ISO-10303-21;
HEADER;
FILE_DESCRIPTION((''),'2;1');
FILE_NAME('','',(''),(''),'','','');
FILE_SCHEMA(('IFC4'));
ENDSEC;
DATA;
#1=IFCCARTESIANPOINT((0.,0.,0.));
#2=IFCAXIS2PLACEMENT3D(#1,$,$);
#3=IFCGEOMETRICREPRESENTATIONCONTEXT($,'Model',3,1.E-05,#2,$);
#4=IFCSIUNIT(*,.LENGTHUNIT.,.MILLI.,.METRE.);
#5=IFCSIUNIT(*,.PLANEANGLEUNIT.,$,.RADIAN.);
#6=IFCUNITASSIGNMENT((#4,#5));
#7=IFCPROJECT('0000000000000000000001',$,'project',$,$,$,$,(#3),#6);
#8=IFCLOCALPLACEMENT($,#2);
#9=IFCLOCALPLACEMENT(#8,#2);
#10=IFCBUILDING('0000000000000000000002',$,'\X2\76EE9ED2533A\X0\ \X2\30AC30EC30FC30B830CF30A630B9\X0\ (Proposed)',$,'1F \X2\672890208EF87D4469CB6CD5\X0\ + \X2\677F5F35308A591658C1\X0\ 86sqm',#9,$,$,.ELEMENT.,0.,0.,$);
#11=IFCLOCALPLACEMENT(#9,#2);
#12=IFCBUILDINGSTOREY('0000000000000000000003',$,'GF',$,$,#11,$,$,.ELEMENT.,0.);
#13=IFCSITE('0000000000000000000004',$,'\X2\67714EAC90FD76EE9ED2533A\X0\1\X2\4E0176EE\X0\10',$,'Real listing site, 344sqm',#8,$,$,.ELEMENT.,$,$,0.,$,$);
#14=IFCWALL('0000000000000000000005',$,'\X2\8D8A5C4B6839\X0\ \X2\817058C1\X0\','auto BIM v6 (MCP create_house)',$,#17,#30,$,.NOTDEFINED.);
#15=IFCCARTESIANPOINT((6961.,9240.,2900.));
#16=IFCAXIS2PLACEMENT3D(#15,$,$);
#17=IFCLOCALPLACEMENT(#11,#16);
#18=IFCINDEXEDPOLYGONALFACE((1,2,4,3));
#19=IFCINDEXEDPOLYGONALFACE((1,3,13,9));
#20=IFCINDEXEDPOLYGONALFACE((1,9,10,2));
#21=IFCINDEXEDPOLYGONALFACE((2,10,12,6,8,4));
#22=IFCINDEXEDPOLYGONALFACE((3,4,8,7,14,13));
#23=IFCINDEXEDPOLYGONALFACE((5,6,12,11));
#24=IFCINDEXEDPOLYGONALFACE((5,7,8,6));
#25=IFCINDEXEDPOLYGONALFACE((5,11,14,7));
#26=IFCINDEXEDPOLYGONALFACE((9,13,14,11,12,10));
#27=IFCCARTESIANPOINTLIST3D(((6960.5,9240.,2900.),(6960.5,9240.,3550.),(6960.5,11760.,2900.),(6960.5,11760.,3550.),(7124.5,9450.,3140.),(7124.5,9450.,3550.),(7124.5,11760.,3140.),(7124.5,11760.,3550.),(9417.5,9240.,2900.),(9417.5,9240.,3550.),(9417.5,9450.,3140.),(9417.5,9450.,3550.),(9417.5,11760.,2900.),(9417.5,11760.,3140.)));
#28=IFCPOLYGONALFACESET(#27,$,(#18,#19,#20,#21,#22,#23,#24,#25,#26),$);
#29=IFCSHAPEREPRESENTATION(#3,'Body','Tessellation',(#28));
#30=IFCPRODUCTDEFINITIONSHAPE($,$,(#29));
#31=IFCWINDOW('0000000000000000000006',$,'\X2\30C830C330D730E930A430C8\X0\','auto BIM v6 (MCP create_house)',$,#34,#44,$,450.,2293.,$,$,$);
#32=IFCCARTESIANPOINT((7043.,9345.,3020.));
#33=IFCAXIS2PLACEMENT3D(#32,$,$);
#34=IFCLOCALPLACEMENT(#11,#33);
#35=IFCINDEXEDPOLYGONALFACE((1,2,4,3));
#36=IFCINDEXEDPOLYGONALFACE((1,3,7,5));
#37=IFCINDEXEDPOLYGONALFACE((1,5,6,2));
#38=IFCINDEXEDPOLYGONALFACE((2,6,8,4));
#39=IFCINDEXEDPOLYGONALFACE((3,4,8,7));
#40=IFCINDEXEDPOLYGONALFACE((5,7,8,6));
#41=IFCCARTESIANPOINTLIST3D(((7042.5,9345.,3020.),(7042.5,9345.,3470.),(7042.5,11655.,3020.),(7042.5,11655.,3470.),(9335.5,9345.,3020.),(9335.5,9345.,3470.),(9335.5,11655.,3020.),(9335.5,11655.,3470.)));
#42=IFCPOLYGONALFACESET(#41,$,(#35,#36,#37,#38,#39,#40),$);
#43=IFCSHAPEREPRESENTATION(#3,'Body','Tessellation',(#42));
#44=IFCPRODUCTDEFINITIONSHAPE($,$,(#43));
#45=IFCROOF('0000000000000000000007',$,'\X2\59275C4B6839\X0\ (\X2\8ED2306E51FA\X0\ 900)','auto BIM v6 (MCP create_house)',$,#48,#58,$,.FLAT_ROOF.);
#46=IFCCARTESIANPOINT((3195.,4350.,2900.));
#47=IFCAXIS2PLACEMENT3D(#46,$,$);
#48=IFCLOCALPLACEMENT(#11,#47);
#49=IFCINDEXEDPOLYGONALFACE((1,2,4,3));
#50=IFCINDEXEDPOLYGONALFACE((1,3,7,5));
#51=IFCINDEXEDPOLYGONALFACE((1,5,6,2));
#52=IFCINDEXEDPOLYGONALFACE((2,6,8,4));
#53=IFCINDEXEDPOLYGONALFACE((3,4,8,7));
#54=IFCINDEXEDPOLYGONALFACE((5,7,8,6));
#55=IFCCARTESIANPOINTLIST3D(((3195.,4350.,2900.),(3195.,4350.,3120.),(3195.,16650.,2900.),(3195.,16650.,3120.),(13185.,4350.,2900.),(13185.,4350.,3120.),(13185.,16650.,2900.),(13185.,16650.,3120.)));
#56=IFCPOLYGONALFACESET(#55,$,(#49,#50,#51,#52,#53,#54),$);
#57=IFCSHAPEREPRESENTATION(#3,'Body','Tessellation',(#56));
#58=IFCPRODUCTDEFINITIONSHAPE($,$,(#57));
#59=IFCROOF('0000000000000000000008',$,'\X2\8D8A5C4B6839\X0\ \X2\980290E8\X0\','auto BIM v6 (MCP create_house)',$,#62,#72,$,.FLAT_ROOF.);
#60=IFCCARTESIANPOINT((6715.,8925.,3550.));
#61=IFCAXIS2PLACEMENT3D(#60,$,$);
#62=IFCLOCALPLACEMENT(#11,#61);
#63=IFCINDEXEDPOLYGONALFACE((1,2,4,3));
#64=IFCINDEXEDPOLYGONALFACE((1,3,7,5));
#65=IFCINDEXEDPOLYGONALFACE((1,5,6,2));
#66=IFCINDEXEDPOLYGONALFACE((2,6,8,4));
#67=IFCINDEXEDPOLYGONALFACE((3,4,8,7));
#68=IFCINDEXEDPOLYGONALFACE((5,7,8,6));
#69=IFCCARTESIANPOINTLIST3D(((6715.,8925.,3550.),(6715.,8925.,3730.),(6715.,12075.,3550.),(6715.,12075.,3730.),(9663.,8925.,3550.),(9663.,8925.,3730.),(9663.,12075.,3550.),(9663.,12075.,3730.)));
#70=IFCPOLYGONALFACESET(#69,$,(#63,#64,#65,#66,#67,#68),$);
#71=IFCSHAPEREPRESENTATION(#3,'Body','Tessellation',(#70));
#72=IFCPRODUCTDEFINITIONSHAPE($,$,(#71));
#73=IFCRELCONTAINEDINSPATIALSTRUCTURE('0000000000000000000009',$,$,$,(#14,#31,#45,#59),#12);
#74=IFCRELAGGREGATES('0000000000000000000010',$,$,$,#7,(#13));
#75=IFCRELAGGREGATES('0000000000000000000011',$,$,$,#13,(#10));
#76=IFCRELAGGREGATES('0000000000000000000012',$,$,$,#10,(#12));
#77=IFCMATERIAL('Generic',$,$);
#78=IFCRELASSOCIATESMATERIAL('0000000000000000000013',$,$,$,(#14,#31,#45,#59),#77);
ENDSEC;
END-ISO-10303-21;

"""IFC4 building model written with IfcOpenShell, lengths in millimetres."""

from ifc_helpers import new_model, si_unit, frame, frame_2d, origin, place, context, project, spatial, rectangle, extrude, material, element, fill, save


model = new_model("IFC4")

# Units and contexts
model_context = context("Model", 3, precision=1e-05, world=origin())
ifc_project = project(units=[si_unit("LENGTHUNIT", "METRE", prefix="MILLI"), si_unit("PLANEANGLEUNIT", "RADIAN")], contexts=[model_context])

# Site, building, storey
site_placement = place(None, origin())
site = spatial("IfcSite", under=ifc_project, at=site_placement, Name="東京都目黒区1丁目10", ObjectType="Real listing site, 344sqm", CompositionType="ELEMENT", RefElevation=0.0)
building_placement = place(site_placement, origin())
building = spatial("IfcBuilding", under=site, at=building_placement, Name="目黒区 ガレージハウス (Proposed)", ObjectType="1F 木造軸組構法 + 板張り外壁 86sqm", CompositionType="ELEMENT", ElevationOfRefHeight=0.0, ElevationOfTerrain=0.0)
storey_placement = place(building_placement, origin())
storey = spatial("IfcBuildingStorey", under=building, at=storey_placement, Name="GF", CompositionType="ELEMENT", Elevation=0.0)

# Shared definitions
ifc_material = material(Name="Generic")

# Wall, opening, window
wall_1_placement = place(storey_placement, frame((6961.0, 9240.0, 2900.0)))
wall_1 = element("IfcWall", 1, at=wall_1_placement, inside=storey, material=ifc_material, Name="越屋根 腰壁", Description="auto BIM v6 (MCP create_house)", PredefinedType="NOTDEFINED", context=model_context, shape_type="SweptSolid", body=[
    extrude(rectangle(XDim=2457.0, YDim=2520.0, at=frame_2d((1228.0, 1260.0))), frame((6961.0, 9240.0, 2900.0)), (0.0, 0.0, 1.0), 650.0),
])
opening_1_placement = place(storey_placement, frame((7043.0, 9345.0, 3020.0)))
opening_1 = element("IfcOpeningElement", 2, at=opening_1_placement, cuts=wall_1, PredefinedType="NOTDEFINED", context=model_context, shape_type="SweptSolid", body=[
    extrude(rectangle(XDim=2293.0, YDim=2310.0, at=frame_2d((1146.0, 1155.0))), frame((7043.0, 9345.0, 3020.0)), (0.0, 0.0, 1.0), 450.0),
])
window_1_placement = place(storey_placement, frame((7043.0, 9345.0, 3020.0)))
window_1 = element("IfcWindow", 3, at=window_1_placement, inside=storey, material=ifc_material, Name="トップライト", Description="auto BIM v6 (MCP create_house)", OverallHeight=450.0, OverallWidth=2293.0, context=model_context, shape_type="SweptSolid", body=[
    extrude(rectangle(XDim=2293.0, YDim=2310.0, at=frame_2d((1146.0, 1155.0))), frame((7043.0, 9345.0, 3020.0)), (0.0, 0.0, 1.0), 450.0),
])
fill(opening_1, window_1)

# Roofs
roof_1_placement = place(storey_placement, frame((3195.0, 4350.0, 2900.0)))
element("IfcRoof", 4, at=roof_1_placement, inside=storey, material=ifc_material, Name="大屋根 (軒の出 900)", Description="auto BIM v6 (MCP create_house)", PredefinedType="FLAT_ROOF", context=model_context, shape_type="SweptSolid", body=[
    extrude(rectangle(XDim=9990.0, YDim=12300.0, at=frame_2d((4995.0, 6150.0))), frame((3195.0, 4350.0, 2900.0)), (0.0, 0.0, 1.0), 220.0),
])
roof_2_placement = place(storey_placement, frame((6715.0, 8925.0, 3550.0)))
element("IfcRoof", 5, at=roof_2_placement, inside=storey, material=ifc_material, Name="越屋根 頂部", Description="auto BIM v6 (MCP create_house)", PredefinedType="FLAT_ROOF", context=model_context, shape_type="SweptSolid", body=[
    extrude(rectangle(XDim=2948.0, YDim=3150.0, at=frame_2d((1474.0, 1575.0))), frame((6715.0, 8925.0, 3550.0)), (0.0, 0.0, 1.0), 180.0),
])

save(model, "model.ifc")
